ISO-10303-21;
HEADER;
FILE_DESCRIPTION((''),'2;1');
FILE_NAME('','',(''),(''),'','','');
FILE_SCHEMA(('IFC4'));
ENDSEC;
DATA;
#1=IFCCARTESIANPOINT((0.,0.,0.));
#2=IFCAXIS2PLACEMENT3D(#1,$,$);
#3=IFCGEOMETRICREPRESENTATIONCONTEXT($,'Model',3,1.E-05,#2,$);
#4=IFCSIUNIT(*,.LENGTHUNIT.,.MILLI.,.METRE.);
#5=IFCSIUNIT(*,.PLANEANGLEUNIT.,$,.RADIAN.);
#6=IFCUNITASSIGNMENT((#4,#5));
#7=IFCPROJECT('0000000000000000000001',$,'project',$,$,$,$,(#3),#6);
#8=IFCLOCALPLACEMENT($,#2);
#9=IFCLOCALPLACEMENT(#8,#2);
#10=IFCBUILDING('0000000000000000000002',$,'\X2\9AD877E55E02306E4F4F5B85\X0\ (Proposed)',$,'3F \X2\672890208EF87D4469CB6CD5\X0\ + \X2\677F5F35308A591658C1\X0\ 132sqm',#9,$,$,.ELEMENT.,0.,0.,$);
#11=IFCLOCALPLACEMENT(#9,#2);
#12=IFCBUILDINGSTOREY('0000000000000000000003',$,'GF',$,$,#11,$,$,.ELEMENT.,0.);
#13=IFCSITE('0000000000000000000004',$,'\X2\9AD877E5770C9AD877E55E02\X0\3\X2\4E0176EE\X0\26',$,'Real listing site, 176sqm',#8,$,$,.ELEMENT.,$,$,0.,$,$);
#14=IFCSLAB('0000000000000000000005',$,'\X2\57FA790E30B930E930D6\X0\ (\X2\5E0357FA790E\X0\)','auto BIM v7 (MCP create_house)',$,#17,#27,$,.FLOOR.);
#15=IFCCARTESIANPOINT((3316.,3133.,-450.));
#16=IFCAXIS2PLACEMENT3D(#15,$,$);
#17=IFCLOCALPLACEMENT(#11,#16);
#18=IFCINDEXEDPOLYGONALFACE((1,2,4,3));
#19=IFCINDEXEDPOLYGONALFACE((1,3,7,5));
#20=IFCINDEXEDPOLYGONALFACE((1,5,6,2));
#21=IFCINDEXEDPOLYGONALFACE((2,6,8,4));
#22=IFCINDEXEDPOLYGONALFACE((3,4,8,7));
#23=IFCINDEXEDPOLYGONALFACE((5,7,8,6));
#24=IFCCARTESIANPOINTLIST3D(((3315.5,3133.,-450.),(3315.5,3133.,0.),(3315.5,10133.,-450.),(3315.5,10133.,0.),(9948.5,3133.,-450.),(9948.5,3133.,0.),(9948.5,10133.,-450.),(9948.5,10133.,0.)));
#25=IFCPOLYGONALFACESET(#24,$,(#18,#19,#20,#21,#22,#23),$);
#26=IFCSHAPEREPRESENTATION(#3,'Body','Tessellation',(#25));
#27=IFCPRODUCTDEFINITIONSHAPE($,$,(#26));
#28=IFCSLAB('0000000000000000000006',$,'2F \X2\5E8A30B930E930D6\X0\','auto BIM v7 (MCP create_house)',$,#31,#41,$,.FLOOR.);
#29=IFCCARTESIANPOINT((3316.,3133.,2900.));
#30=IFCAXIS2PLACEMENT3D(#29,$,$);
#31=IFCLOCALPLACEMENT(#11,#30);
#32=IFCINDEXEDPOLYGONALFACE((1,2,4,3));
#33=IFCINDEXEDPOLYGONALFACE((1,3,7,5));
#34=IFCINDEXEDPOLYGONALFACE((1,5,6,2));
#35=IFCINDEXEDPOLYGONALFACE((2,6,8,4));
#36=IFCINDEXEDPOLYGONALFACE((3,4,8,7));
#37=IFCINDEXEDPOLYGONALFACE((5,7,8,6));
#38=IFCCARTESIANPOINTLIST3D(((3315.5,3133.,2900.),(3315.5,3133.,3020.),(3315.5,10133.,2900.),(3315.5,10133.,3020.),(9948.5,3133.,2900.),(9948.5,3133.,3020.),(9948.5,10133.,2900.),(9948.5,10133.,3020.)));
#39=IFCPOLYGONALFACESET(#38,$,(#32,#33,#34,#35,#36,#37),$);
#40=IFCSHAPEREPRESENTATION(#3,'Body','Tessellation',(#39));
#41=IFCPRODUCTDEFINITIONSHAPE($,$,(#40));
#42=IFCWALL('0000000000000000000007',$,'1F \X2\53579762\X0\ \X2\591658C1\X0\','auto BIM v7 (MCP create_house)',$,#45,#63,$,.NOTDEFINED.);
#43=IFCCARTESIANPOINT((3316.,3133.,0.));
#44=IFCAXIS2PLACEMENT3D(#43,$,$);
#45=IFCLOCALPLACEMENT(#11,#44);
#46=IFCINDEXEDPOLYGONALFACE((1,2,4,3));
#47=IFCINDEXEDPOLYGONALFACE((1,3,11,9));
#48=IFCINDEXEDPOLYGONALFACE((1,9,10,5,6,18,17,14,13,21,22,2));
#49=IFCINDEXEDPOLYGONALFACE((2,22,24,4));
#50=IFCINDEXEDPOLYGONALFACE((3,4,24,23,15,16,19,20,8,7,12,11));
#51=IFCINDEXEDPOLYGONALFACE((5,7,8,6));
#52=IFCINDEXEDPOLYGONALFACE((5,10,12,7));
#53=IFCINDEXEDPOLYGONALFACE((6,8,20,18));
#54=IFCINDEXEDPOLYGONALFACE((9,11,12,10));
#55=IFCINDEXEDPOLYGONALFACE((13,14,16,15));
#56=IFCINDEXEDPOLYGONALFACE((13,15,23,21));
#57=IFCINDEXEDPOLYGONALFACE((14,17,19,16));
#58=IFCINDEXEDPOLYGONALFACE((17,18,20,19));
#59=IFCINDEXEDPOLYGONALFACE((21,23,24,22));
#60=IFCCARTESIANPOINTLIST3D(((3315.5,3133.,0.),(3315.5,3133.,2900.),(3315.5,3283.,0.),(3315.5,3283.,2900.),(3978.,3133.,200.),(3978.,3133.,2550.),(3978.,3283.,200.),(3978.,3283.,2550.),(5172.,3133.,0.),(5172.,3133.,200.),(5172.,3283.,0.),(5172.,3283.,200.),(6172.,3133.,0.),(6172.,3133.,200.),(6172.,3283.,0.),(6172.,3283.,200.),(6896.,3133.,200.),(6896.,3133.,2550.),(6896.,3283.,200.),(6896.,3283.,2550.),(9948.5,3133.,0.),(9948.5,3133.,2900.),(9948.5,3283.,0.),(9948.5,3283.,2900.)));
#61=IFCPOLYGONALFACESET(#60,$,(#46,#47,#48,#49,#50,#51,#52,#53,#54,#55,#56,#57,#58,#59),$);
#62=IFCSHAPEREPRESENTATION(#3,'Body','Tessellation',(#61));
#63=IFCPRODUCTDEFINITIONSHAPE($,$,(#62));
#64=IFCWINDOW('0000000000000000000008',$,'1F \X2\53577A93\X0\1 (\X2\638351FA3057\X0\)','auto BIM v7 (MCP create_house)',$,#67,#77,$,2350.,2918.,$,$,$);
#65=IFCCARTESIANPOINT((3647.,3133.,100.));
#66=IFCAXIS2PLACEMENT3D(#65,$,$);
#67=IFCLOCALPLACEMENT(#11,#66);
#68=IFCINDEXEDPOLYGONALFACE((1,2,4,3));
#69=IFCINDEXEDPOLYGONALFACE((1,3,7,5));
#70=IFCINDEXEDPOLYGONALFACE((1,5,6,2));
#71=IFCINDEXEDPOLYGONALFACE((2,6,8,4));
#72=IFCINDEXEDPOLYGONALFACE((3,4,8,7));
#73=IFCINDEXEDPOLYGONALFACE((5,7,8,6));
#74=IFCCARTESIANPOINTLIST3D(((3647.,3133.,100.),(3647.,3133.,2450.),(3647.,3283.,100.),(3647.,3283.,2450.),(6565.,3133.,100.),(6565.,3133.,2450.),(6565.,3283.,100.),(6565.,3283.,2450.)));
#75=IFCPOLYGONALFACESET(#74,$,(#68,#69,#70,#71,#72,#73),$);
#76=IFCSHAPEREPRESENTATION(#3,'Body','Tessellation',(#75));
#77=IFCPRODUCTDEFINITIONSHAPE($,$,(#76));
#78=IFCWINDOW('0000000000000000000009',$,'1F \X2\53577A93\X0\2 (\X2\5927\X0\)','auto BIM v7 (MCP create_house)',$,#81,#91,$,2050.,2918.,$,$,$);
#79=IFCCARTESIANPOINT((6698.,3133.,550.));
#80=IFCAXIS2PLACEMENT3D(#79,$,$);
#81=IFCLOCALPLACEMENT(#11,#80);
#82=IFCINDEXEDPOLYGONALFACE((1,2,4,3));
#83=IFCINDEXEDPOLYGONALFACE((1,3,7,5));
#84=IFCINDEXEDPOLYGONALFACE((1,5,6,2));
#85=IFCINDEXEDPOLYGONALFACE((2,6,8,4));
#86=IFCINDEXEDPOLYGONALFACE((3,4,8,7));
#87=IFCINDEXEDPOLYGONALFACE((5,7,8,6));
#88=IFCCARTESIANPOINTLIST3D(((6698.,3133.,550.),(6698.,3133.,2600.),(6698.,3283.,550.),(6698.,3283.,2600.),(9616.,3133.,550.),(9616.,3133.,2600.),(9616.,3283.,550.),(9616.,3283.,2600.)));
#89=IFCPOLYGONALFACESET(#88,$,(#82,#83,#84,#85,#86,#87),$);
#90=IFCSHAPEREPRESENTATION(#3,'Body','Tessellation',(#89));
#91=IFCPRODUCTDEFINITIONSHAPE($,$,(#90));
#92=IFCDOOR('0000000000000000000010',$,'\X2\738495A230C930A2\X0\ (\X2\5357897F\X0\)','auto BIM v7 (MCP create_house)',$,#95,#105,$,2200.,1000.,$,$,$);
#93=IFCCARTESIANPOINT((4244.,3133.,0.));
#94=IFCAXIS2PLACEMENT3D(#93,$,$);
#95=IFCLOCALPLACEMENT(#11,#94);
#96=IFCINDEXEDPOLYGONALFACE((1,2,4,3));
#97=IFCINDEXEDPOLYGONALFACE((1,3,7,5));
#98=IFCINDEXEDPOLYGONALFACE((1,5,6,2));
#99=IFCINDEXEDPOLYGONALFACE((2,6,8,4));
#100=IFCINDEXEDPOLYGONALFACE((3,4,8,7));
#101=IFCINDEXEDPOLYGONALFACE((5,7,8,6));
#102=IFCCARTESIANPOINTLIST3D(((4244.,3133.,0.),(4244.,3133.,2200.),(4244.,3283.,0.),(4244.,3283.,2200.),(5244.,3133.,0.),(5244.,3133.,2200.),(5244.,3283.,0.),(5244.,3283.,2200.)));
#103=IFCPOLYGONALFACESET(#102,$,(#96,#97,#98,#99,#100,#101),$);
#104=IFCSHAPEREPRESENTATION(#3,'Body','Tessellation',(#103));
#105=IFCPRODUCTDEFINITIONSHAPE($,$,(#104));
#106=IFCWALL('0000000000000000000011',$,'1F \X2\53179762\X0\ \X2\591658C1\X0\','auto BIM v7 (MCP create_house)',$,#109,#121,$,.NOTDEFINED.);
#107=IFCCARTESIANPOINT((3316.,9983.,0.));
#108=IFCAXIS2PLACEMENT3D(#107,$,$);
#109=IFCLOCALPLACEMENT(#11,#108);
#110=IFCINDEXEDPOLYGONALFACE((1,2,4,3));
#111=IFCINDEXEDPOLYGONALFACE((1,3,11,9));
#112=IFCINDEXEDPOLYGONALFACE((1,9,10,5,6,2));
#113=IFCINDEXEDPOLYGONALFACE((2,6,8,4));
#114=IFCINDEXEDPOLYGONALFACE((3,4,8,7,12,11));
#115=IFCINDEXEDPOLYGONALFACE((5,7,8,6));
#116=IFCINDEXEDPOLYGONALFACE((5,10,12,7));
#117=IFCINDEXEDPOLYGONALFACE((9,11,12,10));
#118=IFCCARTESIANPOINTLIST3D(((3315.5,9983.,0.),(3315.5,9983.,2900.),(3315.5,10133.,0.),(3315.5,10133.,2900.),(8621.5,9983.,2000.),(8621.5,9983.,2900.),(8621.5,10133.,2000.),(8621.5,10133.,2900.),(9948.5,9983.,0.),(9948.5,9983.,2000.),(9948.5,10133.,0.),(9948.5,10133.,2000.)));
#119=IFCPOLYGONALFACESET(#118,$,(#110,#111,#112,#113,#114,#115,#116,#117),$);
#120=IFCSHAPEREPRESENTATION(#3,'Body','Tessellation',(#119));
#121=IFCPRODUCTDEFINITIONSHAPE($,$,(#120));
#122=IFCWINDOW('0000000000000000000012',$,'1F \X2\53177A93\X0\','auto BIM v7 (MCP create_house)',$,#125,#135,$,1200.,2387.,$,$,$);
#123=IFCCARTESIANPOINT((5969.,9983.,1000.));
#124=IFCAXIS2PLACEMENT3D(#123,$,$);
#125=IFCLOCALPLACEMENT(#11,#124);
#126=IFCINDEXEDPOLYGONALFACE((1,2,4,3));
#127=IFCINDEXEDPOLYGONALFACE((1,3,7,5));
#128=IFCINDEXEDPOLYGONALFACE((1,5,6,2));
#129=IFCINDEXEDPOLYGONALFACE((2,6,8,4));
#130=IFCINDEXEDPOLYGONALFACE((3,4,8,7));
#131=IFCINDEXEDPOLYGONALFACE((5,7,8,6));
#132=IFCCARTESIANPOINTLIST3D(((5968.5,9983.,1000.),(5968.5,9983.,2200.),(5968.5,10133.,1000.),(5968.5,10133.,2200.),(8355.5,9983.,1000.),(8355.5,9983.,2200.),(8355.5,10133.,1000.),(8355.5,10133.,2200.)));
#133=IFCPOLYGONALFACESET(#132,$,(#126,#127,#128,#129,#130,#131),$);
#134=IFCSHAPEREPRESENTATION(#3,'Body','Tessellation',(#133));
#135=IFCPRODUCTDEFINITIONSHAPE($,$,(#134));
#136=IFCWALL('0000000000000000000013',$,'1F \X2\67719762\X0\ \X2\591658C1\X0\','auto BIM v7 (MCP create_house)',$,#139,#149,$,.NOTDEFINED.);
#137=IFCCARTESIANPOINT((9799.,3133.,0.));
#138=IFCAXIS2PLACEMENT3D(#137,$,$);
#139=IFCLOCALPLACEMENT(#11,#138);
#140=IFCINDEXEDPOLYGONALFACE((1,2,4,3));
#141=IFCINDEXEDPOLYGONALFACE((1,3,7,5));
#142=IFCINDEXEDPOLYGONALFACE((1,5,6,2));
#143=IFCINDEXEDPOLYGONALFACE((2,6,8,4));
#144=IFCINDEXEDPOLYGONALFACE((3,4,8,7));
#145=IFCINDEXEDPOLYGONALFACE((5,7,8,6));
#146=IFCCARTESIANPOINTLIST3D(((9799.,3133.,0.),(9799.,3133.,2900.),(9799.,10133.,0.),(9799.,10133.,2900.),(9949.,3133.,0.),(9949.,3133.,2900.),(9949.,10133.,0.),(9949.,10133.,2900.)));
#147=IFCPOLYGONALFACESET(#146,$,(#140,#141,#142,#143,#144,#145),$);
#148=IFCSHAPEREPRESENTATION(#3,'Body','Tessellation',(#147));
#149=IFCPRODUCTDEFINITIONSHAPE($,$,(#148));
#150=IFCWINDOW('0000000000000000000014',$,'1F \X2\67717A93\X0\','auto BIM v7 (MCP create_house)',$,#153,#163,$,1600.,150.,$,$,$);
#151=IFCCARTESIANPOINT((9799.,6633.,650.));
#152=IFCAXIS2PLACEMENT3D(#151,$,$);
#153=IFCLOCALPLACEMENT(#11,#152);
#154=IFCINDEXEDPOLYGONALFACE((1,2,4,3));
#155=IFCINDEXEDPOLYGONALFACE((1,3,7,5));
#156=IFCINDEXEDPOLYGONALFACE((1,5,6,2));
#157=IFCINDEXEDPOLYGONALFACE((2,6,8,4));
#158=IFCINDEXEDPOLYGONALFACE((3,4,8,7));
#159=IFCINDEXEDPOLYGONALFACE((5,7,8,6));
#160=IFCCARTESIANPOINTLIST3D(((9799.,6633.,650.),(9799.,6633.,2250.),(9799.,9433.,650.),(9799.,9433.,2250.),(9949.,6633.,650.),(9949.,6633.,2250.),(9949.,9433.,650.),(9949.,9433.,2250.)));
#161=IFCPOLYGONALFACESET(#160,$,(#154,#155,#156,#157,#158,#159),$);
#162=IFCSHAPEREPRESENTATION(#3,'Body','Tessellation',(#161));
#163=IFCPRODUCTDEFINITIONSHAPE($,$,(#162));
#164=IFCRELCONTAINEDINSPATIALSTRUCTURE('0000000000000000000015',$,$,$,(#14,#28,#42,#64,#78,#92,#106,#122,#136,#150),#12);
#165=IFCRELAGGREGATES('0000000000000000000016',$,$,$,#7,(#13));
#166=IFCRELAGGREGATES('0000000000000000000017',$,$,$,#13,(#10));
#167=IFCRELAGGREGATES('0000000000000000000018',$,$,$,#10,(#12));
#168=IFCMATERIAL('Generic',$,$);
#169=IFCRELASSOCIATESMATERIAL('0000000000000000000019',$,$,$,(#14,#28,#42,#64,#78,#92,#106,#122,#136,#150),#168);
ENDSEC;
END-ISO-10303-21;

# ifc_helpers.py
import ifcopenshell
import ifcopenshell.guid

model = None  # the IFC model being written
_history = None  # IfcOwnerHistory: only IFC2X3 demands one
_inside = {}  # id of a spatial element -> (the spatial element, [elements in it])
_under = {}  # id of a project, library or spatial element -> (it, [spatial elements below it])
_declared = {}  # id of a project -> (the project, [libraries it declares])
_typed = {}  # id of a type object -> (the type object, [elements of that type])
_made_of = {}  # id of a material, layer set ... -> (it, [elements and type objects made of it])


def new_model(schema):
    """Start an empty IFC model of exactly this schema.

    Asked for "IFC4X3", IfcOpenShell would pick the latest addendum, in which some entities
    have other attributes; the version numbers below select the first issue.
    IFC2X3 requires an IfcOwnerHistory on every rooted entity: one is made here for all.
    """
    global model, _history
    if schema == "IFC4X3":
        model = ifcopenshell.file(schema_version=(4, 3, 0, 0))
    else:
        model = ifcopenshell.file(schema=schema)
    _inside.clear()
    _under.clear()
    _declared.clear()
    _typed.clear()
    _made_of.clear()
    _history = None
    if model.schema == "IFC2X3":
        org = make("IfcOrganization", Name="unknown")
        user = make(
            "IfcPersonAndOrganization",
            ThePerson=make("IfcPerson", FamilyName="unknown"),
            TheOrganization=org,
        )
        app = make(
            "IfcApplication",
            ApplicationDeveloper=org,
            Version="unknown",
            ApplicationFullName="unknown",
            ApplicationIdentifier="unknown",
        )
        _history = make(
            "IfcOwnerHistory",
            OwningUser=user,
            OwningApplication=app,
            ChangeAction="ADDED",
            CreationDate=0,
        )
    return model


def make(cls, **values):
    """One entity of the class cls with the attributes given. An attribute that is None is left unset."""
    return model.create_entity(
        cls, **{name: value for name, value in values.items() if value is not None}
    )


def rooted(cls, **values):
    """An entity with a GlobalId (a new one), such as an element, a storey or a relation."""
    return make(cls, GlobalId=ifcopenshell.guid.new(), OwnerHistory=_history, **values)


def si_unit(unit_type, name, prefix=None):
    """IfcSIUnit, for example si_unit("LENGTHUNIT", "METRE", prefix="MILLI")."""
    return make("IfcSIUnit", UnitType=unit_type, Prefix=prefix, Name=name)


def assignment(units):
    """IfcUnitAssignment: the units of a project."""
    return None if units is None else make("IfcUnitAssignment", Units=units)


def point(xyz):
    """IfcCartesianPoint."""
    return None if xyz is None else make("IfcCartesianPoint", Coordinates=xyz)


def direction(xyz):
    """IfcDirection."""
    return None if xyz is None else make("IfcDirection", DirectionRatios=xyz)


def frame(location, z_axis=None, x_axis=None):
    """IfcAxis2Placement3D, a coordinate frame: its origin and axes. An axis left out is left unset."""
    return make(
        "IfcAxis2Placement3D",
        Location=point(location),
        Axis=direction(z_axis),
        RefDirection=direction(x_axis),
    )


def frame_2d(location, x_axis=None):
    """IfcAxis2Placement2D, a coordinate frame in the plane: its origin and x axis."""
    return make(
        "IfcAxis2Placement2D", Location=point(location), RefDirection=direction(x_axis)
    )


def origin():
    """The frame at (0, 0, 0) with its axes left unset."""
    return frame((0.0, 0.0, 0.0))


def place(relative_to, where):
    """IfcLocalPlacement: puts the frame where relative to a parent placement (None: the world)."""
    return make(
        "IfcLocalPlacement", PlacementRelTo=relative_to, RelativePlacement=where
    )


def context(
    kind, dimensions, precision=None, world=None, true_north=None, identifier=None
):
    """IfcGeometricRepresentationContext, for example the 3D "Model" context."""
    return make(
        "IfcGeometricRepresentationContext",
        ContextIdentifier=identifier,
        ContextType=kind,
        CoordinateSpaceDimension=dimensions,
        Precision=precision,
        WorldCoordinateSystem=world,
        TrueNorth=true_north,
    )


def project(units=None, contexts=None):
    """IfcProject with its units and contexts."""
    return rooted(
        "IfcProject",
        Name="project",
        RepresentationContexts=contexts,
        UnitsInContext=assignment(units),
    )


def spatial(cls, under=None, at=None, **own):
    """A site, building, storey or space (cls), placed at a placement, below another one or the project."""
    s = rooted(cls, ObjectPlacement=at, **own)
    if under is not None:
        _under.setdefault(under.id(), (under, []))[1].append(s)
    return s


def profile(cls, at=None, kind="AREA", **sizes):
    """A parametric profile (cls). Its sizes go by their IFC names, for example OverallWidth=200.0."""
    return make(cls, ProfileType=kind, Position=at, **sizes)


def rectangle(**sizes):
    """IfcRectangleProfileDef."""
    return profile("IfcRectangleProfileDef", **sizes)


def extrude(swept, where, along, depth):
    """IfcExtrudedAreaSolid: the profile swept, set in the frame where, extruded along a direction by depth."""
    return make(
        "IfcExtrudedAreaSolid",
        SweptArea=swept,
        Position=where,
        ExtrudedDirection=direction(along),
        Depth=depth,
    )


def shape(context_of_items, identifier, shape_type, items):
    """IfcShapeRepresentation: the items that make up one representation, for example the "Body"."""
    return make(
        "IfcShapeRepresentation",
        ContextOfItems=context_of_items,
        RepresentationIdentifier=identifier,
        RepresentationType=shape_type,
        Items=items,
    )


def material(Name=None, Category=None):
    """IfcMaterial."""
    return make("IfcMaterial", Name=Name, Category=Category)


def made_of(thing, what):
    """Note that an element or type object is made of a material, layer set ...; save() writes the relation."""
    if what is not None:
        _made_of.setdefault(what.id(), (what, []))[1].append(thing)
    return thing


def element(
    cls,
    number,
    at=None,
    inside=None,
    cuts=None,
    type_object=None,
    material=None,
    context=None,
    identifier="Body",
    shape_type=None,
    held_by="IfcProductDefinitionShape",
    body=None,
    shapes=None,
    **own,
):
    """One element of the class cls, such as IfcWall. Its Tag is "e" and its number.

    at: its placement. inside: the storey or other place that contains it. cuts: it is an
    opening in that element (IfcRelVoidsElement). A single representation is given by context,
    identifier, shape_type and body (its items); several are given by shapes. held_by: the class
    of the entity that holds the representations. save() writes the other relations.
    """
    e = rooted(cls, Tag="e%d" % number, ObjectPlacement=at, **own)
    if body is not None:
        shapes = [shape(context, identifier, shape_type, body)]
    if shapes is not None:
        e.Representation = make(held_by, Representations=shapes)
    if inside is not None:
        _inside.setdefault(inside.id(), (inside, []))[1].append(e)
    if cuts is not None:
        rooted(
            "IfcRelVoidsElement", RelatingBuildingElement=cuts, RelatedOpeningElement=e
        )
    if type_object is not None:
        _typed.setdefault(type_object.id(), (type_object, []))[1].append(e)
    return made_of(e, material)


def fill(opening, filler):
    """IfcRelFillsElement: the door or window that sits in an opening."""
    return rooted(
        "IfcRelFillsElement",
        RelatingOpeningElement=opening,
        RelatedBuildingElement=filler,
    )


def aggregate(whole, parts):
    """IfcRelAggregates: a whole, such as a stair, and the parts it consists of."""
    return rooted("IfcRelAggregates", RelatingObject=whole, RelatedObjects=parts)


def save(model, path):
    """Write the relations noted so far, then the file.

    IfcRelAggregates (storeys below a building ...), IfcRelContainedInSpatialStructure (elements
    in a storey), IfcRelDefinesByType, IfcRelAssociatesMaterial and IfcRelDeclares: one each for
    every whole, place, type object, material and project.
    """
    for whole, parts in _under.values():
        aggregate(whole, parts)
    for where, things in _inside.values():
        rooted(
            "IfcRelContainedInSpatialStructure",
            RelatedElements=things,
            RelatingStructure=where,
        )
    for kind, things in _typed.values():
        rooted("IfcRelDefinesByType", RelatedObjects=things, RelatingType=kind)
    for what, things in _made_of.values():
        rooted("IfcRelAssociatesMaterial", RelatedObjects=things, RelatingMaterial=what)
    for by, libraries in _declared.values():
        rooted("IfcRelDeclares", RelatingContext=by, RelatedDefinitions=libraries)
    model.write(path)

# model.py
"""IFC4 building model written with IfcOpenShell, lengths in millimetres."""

from ifc_helpers import new_model, si_unit, frame, frame_2d, origin, place, context, project, spatial, rectangle, extrude, material, element, fill, save


model = new_model("IFC4")

# Units and contexts
model_context = context("Model", 3, precision=1e-05, world=origin())
ifc_project = project(units=[si_unit("LENGTHUNIT", "METRE", prefix="MILLI"), si_unit("PLANEANGLEUNIT", "RADIAN")], contexts=[model_context])

# Site, building, storey
site_placement = place(None, origin())
site = spatial("IfcSite", under=ifc_project, at=site_placement, Name="高知県高知市3丁目26", ObjectType="Real listing site, 176sqm", CompositionType="ELEMENT", RefElevation=0.0)
building_placement = place(site_placement, origin())
building = spatial("IfcBuilding", under=site, at=building_placement, Name="高知市の住宅 (Proposed)", ObjectType="3F 木造軸組構法 + 板張り外壁 132sqm", CompositionType="ELEMENT", ElevationOfRefHeight=0.0, ElevationOfTerrain=0.0)
storey_placement = place(building_placement, origin())
storey = spatial("IfcBuildingStorey", under=building, at=storey_placement, Name="GF", CompositionType="ELEMENT", Elevation=0.0)

# Slabs
ifc_material = material(Name="Generic")
slab_1_placement = place(storey_placement, frame((3316.0, 3133.0, -450.0)))
element("IfcSlab", 1, at=slab_1_placement, inside=storey, material=ifc_material, Name="基礎スラブ (布基礎)", Description="auto BIM v7 (MCP create_house)", PredefinedType="FLOOR", context=model_context, shape_type="SweptSolid", body=[
    extrude(rectangle(XDim=6633.0, YDim=7000.0, at=frame_2d((3316.0, 3500.0))), frame((3316.0, 3133.0, -450.0)), (0.0, 0.0, 1.0), 450.0),
])
slab_2_placement = place(storey_placement, frame((3316.0, 3133.0, 2900.0)))
element("IfcSlab", 2, at=slab_2_placement, inside=storey, material=ifc_material, Name="2F 床スラブ", Description="auto BIM v7 (MCP create_house)", PredefinedType="FLOOR", context=model_context, shape_type="SweptSolid", body=[
    extrude(rectangle(XDim=6633.0, YDim=7000.0, at=frame_2d((3316.0, 3500.0))), frame((3316.0, 3133.0, 2900.0)), (0.0, 0.0, 1.0), 120.0),
])

# Wall, openings, windows, door
wall_1_placement = place(storey_placement, frame((3316.0, 3133.0, 0.0)))
wall_1 = element("IfcWall", 3, at=wall_1_placement, inside=storey, material=ifc_material, Name="1F 南面 外壁", Description="auto BIM v7 (MCP create_house)", PredefinedType="NOTDEFINED", context=model_context, shape_type="SweptSolid", body=[
    extrude(rectangle(XDim=6633.0, YDim=150.0, at=frame_2d((3316.0, 75.0))), frame((3316.0, 3133.0, 0.0)), (0.0, 0.0, 1.0), 2900.0),
])
opening_1_placement = place(storey_placement, frame((3647.0, 3133.0, 100.0)))
opening_1 = element("IfcOpeningElement", 4, at=opening_1_placement, cuts=wall_1, PredefinedType="NOTDEFINED", context=model_context, shape_type="SweptSolid", body=[
    extrude(rectangle(XDim=2918.0, YDim=150.0, at=frame_2d((1459.0, 75.0))), frame((3647.0, 3133.0, 100.0)), (0.0, 0.0, 1.0), 2350.0),
])
opening_2_placement = place(storey_placement, frame((6698.0, 3133.0, 550.0)))
opening_2 = element("IfcOpeningElement", 5, at=opening_2_placement, cuts=wall_1, PredefinedType="NOTDEFINED", context=model_context, shape_type="SweptSolid", body=[
    extrude(rectangle(XDim=2918.0, YDim=150.0, at=frame_2d((1459.0, 75.0))), frame((6698.0, 3133.0, 550.0)), (0.0, 0.0, 1.0), 2050.0),
])
opening_3_placement = place(storey_placement, frame((4244.0, 3133.0, 0.0)))
opening_3 = element("IfcOpeningElement", 6, at=opening_3_placement, cuts=wall_1, PredefinedType="NOTDEFINED", context=model_context, shape_type="SweptSolid", body=[
    extrude(rectangle(XDim=1000.0, YDim=150.0, at=frame_2d((500.0, 75.0))), frame((4244.0, 3133.0, 0.0)), (0.0, 0.0, 1.0), 2200.0),
])
window_1_placement = place(storey_placement, frame((3647.0, 3133.0, 100.0)))
window_1 = element("IfcWindow", 7, at=window_1_placement, inside=storey, material=ifc_material, Name="1F 南窓1 (掃出し)", Description="auto BIM v7 (MCP create_house)", OverallHeight=2350.0, OverallWidth=2918.0, context=model_context, shape_type="SweptSolid", body=[
    extrude(rectangle(XDim=2918.0, YDim=150.0, at=frame_2d((1459.0, 75.0))), frame((3647.0, 3133.0, 100.0)), (0.0, 0.0, 1.0), 2350.0),
])
fill(opening_1, window_1)
window_2_placement = place(storey_placement, frame((6698.0, 3133.0, 550.0)))
window_2 = element("IfcWindow", 8, at=window_2_placement, inside=storey, material=ifc_material, Name="1F 南窓2 (大)", Description="auto BIM v7 (MCP create_house)", OverallHeight=2050.0, OverallWidth=2918.0, context=model_context, shape_type="SweptSolid", body=[
    extrude(rectangle(XDim=2918.0, YDim=150.0, at=frame_2d((1459.0, 75.0))), frame((6698.0, 3133.0, 550.0)), (0.0, 0.0, 1.0), 2050.0),
])
fill(opening_2, window_2)
door_placement = place(storey_placement, frame((4244.0, 3133.0, 0.0)))
door = element("IfcDoor", 9, at=door_placement, inside=storey, material=ifc_material, Name="玄関ドア (南西)", Description="auto BIM v7 (MCP create_house)", OverallHeight=2200.0, OverallWidth=1000.0, context=model_context, shape_type="SweptSolid", body=[
    extrude(rectangle(XDim=1000.0, YDim=150.0, at=frame_2d((500.0, 75.0))), frame((4244.0, 3133.0, 0.0)), (0.0, 0.0, 1.0), 2200.0),
])
fill(opening_3, door)

# Walls, openings, windows
wall_2_placement = place(storey_placement, frame((3316.0, 9983.0, 0.0)))
wall_2 = element("IfcWall", 10, at=wall_2_placement, inside=storey, material=ifc_material, Name="1F 北面 外壁", Description="auto BIM v7 (MCP create_house)", PredefinedType="NOTDEFINED", context=model_context, shape_type="SweptSolid", body=[
    extrude(rectangle(XDim=6633.0, YDim=150.0, at=frame_2d((3316.0, 75.0))), frame((3316.0, 9983.0, 0.0)), (0.0, 0.0, 1.0), 2900.0),
])
opening_4_placement = place(storey_placement, frame((5969.0, 9983.0, 1000.0)))
opening_4 = element("IfcOpeningElement", 11, at=opening_4_placement, cuts=wall_2, PredefinedType="NOTDEFINED", context=model_context, shape_type="SweptSolid", body=[
    extrude(rectangle(XDim=2387.0, YDim=150.0, at=frame_2d((1193.0, 75.0))), frame((5969.0, 9983.0, 1000.0)), (0.0, 0.0, 1.0), 1200.0),
])
window_3_placement = place(storey_placement, frame((5969.0, 9983.0, 1000.0)))
window_3 = element("IfcWindow", 12, at=window_3_placement, inside=storey, material=ifc_material, Name="1F 北窓", Description="auto BIM v7 (MCP create_house)", OverallHeight=1200.0, OverallWidth=2387.0, context=model_context, shape_type="SweptSolid", body=[
    extrude(rectangle(XDim=2387.0, YDim=150.0, at=frame_2d((1193.0, 75.0))), frame((5969.0, 9983.0, 1000.0)), (0.0, 0.0, 1.0), 1200.0),
])
fill(opening_4, window_3)
wall_3_placement = place(storey_placement, frame((9799.0, 3133.0, 0.0)))
wall_3 = element("IfcWall", 13, at=wall_3_placement, inside=storey, material=ifc_material, Name="1F 東面 外壁", Description="auto BIM v7 (MCP create_house)", PredefinedType="NOTDEFINED", context=model_context, shape_type="SweptSolid", body=[
    extrude(rectangle(XDim=150.0, YDim=7000.0, at=frame_2d((75.0, 3500.0))), frame((9799.0, 3133.0, 0.0)), (0.0, 0.0, 1.0), 2900.0),
])
opening_5_placement = place(storey_placement, frame((9799.0, 6633.0, 650.0)))
opening_5 = element("IfcOpeningElement", 14, at=opening_5_placement, cuts=wall_3, PredefinedType="NOTDEFINED", context=model_context, shape_type="SweptSolid", body=[
    extrude(rectangle(XDim=150.0, YDim=2800.0, at=frame_2d((75.0, 1400.0))), frame((9799.0, 6633.0, 650.0)), (0.0, 0.0, 1.0), 1600.0),
])
window_4_placement = place(storey_placement, frame((9799.0, 6633.0, 650.0)))
window_4 = element("IfcWindow", 15, at=window_4_placement, inside=storey, material=ifc_material, Name="1F 東窓", Description="auto BIM v7 (MCP create_house)", OverallHeight=1600.0, OverallWidth=150.0, context=model_context, shape_type="SweptSolid", body=[
    extrude(rectangle(XDim=150.0, YDim=2800.0, at=frame_2d((75.0, 1400.0))), frame((9799.0, 6633.0, 650.0)), (0.0, 0.0, 1.0), 1600.0),
])
fill(opening_5, window_4)

save(model, "model.ifc")
